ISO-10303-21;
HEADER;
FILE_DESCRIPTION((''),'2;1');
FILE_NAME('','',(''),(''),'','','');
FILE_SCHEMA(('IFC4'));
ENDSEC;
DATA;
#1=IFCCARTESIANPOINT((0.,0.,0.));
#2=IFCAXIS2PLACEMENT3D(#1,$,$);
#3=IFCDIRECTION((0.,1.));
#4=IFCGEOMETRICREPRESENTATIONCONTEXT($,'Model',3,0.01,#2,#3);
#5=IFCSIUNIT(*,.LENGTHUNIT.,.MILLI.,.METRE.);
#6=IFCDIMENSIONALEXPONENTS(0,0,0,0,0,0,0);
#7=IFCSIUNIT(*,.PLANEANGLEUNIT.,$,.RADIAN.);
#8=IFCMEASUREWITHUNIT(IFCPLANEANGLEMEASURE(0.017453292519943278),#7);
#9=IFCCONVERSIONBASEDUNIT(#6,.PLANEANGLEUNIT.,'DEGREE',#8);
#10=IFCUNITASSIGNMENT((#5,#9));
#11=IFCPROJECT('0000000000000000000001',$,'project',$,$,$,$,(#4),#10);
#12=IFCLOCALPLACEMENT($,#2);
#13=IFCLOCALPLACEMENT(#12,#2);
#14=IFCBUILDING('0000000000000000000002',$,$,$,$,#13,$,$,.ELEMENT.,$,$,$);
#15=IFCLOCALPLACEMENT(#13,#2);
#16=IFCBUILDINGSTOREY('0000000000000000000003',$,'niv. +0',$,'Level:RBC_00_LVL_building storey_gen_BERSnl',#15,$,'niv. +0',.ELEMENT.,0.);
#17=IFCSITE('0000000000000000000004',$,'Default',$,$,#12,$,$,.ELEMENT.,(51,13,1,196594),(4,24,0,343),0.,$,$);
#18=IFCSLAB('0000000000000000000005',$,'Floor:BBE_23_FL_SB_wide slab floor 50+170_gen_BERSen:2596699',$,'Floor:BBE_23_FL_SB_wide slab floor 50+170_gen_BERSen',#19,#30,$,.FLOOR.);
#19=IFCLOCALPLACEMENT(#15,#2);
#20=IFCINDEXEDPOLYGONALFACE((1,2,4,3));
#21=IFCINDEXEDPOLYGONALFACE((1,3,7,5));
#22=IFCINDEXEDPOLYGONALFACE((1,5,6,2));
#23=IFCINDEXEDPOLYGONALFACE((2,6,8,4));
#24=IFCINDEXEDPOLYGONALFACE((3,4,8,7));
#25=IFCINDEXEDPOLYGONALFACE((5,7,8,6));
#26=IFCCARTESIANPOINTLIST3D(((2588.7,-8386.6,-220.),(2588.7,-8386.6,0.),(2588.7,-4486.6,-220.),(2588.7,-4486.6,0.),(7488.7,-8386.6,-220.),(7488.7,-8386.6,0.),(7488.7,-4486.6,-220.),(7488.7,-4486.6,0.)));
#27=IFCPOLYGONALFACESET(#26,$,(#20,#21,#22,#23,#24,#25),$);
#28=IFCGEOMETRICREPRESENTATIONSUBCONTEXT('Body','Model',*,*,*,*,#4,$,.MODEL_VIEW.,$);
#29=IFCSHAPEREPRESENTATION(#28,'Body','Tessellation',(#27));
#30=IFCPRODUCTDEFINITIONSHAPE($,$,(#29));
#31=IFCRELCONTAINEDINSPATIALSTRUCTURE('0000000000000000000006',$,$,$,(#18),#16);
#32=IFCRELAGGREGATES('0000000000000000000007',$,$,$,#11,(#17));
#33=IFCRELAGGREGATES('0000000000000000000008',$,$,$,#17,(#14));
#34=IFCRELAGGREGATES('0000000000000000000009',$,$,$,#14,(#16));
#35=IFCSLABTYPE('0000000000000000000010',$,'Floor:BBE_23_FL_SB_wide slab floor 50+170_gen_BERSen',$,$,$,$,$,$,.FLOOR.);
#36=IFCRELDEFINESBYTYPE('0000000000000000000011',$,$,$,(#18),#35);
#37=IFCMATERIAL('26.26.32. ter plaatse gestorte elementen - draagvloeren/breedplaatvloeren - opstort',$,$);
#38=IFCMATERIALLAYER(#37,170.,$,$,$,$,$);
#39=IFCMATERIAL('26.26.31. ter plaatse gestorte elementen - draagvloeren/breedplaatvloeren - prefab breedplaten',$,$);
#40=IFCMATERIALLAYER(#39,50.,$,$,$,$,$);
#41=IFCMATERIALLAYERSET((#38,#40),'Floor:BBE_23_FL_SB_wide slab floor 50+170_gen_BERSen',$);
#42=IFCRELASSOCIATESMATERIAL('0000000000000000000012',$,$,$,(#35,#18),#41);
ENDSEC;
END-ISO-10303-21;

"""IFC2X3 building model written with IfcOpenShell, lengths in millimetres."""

from ifc_helpers import new_model, entity, si_unit, converted_unit, direction, frame, frame_2d, origin, place, context, subcontext, project, spatial, rectangle, extrude, material, layer, layer_set, layer_usage, type_object, element, save


model = new_model("IFC2X3")

# Units and contexts
model_context = context("Model", 3, precision=0.01, world=origin(), true_north=direction((0.0, 1.0)))
body_context = subcontext(model_context, "Body", "Model", "MODEL_VIEW")
ifc_project = project(units=[si_unit("LENGTHUNIT", "METRE", prefix="MILLI"), converted_unit("PLANEANGLEUNIT", "DEGREE", entity("IfcPlaneAngleMeasure", 0.017453292519943278), si_unit("PLANEANGLEUNIT", "RADIAN"), dimensions=[0, 0, 0, 0, 0, 0, 0])], contexts=[model_context])

# Site, building, storey
site_placement = place(None, origin())
site = spatial("IfcSite", under=ifc_project, at=site_placement, Name="Default", CompositionType="ELEMENT", RefLatitude=(51, 13, 1, 196594), RefLongitude=(4, 24, 0, 343), RefElevation=0.0)
building_placement = place(site_placement, origin())
building = spatial("IfcBuilding", under=site, at=building_placement, CompositionType="ELEMENT")
storey_placement = place(building_placement, origin())
storey = spatial("IfcBuildingStorey", under=building, at=storey_placement, Name="niv. +0", ObjectType="Level:RBC_00_LVL_building storey_gen_BERSnl", LongName="niv. +0", CompositionType="ELEMENT", Elevation=0.0)

# Slab
ifc_material_1 = material(Name="26.26.32. ter plaatse gestorte elementen - draagvloeren/breedplaatvloeren - opstort")
ifc_layer_1 = layer(ifc_material_1, 170.0)
ifc_material_2 = material(Name="26.26.31. ter plaatse gestorte elementen - draagvloeren/breedplaatvloeren - prefab breedplaten")
ifc_layer_2 = layer(ifc_material_2, 50.0)
ifc_layer_set = layer_set([ifc_layer_1, ifc_layer_2], Name="Floor:BBE_23_FL_SB_wide slab floor 50+170_gen_BERSen")
ifc_layer_usage = layer_usage(ifc_layer_set, "AXIS3", "POSITIVE", 0.0)
slab_type = type_object("IfcSlabType", Name="Floor:BBE_23_FL_SB_wide slab floor 50+170_gen_BERSen", PredefinedType="FLOOR", material=ifc_layer_set)
slab_placement = place(storey_placement, origin())
element("IfcSlab", 1, at=slab_placement, inside=storey, type_object=slab_type, material=ifc_layer_usage, Name="Floor:BBE_23_FL_SB_wide slab floor 50+170_gen_BERSen:2596699", ObjectType="Floor:BBE_23_FL_SB_wide slab floor 50+170_gen_BERSen", PredefinedType="FLOOR", context=body_context, shape_type="SweptSolid", body=[
    extrude(rectangle(XDim=3900.0, YDim=4900.0, at=frame_2d((0.0, 0.0), x_axis=(1.0, 0.0))), frame((5038.7, -6436.6, 0.0), z_axis=(0.0, 0.0, -1.0), x_axis=(0.0, 1.0, 0.0)), (0.0, 0.0, 1.0), 220.0),
])

save(model, "model.ifc")
